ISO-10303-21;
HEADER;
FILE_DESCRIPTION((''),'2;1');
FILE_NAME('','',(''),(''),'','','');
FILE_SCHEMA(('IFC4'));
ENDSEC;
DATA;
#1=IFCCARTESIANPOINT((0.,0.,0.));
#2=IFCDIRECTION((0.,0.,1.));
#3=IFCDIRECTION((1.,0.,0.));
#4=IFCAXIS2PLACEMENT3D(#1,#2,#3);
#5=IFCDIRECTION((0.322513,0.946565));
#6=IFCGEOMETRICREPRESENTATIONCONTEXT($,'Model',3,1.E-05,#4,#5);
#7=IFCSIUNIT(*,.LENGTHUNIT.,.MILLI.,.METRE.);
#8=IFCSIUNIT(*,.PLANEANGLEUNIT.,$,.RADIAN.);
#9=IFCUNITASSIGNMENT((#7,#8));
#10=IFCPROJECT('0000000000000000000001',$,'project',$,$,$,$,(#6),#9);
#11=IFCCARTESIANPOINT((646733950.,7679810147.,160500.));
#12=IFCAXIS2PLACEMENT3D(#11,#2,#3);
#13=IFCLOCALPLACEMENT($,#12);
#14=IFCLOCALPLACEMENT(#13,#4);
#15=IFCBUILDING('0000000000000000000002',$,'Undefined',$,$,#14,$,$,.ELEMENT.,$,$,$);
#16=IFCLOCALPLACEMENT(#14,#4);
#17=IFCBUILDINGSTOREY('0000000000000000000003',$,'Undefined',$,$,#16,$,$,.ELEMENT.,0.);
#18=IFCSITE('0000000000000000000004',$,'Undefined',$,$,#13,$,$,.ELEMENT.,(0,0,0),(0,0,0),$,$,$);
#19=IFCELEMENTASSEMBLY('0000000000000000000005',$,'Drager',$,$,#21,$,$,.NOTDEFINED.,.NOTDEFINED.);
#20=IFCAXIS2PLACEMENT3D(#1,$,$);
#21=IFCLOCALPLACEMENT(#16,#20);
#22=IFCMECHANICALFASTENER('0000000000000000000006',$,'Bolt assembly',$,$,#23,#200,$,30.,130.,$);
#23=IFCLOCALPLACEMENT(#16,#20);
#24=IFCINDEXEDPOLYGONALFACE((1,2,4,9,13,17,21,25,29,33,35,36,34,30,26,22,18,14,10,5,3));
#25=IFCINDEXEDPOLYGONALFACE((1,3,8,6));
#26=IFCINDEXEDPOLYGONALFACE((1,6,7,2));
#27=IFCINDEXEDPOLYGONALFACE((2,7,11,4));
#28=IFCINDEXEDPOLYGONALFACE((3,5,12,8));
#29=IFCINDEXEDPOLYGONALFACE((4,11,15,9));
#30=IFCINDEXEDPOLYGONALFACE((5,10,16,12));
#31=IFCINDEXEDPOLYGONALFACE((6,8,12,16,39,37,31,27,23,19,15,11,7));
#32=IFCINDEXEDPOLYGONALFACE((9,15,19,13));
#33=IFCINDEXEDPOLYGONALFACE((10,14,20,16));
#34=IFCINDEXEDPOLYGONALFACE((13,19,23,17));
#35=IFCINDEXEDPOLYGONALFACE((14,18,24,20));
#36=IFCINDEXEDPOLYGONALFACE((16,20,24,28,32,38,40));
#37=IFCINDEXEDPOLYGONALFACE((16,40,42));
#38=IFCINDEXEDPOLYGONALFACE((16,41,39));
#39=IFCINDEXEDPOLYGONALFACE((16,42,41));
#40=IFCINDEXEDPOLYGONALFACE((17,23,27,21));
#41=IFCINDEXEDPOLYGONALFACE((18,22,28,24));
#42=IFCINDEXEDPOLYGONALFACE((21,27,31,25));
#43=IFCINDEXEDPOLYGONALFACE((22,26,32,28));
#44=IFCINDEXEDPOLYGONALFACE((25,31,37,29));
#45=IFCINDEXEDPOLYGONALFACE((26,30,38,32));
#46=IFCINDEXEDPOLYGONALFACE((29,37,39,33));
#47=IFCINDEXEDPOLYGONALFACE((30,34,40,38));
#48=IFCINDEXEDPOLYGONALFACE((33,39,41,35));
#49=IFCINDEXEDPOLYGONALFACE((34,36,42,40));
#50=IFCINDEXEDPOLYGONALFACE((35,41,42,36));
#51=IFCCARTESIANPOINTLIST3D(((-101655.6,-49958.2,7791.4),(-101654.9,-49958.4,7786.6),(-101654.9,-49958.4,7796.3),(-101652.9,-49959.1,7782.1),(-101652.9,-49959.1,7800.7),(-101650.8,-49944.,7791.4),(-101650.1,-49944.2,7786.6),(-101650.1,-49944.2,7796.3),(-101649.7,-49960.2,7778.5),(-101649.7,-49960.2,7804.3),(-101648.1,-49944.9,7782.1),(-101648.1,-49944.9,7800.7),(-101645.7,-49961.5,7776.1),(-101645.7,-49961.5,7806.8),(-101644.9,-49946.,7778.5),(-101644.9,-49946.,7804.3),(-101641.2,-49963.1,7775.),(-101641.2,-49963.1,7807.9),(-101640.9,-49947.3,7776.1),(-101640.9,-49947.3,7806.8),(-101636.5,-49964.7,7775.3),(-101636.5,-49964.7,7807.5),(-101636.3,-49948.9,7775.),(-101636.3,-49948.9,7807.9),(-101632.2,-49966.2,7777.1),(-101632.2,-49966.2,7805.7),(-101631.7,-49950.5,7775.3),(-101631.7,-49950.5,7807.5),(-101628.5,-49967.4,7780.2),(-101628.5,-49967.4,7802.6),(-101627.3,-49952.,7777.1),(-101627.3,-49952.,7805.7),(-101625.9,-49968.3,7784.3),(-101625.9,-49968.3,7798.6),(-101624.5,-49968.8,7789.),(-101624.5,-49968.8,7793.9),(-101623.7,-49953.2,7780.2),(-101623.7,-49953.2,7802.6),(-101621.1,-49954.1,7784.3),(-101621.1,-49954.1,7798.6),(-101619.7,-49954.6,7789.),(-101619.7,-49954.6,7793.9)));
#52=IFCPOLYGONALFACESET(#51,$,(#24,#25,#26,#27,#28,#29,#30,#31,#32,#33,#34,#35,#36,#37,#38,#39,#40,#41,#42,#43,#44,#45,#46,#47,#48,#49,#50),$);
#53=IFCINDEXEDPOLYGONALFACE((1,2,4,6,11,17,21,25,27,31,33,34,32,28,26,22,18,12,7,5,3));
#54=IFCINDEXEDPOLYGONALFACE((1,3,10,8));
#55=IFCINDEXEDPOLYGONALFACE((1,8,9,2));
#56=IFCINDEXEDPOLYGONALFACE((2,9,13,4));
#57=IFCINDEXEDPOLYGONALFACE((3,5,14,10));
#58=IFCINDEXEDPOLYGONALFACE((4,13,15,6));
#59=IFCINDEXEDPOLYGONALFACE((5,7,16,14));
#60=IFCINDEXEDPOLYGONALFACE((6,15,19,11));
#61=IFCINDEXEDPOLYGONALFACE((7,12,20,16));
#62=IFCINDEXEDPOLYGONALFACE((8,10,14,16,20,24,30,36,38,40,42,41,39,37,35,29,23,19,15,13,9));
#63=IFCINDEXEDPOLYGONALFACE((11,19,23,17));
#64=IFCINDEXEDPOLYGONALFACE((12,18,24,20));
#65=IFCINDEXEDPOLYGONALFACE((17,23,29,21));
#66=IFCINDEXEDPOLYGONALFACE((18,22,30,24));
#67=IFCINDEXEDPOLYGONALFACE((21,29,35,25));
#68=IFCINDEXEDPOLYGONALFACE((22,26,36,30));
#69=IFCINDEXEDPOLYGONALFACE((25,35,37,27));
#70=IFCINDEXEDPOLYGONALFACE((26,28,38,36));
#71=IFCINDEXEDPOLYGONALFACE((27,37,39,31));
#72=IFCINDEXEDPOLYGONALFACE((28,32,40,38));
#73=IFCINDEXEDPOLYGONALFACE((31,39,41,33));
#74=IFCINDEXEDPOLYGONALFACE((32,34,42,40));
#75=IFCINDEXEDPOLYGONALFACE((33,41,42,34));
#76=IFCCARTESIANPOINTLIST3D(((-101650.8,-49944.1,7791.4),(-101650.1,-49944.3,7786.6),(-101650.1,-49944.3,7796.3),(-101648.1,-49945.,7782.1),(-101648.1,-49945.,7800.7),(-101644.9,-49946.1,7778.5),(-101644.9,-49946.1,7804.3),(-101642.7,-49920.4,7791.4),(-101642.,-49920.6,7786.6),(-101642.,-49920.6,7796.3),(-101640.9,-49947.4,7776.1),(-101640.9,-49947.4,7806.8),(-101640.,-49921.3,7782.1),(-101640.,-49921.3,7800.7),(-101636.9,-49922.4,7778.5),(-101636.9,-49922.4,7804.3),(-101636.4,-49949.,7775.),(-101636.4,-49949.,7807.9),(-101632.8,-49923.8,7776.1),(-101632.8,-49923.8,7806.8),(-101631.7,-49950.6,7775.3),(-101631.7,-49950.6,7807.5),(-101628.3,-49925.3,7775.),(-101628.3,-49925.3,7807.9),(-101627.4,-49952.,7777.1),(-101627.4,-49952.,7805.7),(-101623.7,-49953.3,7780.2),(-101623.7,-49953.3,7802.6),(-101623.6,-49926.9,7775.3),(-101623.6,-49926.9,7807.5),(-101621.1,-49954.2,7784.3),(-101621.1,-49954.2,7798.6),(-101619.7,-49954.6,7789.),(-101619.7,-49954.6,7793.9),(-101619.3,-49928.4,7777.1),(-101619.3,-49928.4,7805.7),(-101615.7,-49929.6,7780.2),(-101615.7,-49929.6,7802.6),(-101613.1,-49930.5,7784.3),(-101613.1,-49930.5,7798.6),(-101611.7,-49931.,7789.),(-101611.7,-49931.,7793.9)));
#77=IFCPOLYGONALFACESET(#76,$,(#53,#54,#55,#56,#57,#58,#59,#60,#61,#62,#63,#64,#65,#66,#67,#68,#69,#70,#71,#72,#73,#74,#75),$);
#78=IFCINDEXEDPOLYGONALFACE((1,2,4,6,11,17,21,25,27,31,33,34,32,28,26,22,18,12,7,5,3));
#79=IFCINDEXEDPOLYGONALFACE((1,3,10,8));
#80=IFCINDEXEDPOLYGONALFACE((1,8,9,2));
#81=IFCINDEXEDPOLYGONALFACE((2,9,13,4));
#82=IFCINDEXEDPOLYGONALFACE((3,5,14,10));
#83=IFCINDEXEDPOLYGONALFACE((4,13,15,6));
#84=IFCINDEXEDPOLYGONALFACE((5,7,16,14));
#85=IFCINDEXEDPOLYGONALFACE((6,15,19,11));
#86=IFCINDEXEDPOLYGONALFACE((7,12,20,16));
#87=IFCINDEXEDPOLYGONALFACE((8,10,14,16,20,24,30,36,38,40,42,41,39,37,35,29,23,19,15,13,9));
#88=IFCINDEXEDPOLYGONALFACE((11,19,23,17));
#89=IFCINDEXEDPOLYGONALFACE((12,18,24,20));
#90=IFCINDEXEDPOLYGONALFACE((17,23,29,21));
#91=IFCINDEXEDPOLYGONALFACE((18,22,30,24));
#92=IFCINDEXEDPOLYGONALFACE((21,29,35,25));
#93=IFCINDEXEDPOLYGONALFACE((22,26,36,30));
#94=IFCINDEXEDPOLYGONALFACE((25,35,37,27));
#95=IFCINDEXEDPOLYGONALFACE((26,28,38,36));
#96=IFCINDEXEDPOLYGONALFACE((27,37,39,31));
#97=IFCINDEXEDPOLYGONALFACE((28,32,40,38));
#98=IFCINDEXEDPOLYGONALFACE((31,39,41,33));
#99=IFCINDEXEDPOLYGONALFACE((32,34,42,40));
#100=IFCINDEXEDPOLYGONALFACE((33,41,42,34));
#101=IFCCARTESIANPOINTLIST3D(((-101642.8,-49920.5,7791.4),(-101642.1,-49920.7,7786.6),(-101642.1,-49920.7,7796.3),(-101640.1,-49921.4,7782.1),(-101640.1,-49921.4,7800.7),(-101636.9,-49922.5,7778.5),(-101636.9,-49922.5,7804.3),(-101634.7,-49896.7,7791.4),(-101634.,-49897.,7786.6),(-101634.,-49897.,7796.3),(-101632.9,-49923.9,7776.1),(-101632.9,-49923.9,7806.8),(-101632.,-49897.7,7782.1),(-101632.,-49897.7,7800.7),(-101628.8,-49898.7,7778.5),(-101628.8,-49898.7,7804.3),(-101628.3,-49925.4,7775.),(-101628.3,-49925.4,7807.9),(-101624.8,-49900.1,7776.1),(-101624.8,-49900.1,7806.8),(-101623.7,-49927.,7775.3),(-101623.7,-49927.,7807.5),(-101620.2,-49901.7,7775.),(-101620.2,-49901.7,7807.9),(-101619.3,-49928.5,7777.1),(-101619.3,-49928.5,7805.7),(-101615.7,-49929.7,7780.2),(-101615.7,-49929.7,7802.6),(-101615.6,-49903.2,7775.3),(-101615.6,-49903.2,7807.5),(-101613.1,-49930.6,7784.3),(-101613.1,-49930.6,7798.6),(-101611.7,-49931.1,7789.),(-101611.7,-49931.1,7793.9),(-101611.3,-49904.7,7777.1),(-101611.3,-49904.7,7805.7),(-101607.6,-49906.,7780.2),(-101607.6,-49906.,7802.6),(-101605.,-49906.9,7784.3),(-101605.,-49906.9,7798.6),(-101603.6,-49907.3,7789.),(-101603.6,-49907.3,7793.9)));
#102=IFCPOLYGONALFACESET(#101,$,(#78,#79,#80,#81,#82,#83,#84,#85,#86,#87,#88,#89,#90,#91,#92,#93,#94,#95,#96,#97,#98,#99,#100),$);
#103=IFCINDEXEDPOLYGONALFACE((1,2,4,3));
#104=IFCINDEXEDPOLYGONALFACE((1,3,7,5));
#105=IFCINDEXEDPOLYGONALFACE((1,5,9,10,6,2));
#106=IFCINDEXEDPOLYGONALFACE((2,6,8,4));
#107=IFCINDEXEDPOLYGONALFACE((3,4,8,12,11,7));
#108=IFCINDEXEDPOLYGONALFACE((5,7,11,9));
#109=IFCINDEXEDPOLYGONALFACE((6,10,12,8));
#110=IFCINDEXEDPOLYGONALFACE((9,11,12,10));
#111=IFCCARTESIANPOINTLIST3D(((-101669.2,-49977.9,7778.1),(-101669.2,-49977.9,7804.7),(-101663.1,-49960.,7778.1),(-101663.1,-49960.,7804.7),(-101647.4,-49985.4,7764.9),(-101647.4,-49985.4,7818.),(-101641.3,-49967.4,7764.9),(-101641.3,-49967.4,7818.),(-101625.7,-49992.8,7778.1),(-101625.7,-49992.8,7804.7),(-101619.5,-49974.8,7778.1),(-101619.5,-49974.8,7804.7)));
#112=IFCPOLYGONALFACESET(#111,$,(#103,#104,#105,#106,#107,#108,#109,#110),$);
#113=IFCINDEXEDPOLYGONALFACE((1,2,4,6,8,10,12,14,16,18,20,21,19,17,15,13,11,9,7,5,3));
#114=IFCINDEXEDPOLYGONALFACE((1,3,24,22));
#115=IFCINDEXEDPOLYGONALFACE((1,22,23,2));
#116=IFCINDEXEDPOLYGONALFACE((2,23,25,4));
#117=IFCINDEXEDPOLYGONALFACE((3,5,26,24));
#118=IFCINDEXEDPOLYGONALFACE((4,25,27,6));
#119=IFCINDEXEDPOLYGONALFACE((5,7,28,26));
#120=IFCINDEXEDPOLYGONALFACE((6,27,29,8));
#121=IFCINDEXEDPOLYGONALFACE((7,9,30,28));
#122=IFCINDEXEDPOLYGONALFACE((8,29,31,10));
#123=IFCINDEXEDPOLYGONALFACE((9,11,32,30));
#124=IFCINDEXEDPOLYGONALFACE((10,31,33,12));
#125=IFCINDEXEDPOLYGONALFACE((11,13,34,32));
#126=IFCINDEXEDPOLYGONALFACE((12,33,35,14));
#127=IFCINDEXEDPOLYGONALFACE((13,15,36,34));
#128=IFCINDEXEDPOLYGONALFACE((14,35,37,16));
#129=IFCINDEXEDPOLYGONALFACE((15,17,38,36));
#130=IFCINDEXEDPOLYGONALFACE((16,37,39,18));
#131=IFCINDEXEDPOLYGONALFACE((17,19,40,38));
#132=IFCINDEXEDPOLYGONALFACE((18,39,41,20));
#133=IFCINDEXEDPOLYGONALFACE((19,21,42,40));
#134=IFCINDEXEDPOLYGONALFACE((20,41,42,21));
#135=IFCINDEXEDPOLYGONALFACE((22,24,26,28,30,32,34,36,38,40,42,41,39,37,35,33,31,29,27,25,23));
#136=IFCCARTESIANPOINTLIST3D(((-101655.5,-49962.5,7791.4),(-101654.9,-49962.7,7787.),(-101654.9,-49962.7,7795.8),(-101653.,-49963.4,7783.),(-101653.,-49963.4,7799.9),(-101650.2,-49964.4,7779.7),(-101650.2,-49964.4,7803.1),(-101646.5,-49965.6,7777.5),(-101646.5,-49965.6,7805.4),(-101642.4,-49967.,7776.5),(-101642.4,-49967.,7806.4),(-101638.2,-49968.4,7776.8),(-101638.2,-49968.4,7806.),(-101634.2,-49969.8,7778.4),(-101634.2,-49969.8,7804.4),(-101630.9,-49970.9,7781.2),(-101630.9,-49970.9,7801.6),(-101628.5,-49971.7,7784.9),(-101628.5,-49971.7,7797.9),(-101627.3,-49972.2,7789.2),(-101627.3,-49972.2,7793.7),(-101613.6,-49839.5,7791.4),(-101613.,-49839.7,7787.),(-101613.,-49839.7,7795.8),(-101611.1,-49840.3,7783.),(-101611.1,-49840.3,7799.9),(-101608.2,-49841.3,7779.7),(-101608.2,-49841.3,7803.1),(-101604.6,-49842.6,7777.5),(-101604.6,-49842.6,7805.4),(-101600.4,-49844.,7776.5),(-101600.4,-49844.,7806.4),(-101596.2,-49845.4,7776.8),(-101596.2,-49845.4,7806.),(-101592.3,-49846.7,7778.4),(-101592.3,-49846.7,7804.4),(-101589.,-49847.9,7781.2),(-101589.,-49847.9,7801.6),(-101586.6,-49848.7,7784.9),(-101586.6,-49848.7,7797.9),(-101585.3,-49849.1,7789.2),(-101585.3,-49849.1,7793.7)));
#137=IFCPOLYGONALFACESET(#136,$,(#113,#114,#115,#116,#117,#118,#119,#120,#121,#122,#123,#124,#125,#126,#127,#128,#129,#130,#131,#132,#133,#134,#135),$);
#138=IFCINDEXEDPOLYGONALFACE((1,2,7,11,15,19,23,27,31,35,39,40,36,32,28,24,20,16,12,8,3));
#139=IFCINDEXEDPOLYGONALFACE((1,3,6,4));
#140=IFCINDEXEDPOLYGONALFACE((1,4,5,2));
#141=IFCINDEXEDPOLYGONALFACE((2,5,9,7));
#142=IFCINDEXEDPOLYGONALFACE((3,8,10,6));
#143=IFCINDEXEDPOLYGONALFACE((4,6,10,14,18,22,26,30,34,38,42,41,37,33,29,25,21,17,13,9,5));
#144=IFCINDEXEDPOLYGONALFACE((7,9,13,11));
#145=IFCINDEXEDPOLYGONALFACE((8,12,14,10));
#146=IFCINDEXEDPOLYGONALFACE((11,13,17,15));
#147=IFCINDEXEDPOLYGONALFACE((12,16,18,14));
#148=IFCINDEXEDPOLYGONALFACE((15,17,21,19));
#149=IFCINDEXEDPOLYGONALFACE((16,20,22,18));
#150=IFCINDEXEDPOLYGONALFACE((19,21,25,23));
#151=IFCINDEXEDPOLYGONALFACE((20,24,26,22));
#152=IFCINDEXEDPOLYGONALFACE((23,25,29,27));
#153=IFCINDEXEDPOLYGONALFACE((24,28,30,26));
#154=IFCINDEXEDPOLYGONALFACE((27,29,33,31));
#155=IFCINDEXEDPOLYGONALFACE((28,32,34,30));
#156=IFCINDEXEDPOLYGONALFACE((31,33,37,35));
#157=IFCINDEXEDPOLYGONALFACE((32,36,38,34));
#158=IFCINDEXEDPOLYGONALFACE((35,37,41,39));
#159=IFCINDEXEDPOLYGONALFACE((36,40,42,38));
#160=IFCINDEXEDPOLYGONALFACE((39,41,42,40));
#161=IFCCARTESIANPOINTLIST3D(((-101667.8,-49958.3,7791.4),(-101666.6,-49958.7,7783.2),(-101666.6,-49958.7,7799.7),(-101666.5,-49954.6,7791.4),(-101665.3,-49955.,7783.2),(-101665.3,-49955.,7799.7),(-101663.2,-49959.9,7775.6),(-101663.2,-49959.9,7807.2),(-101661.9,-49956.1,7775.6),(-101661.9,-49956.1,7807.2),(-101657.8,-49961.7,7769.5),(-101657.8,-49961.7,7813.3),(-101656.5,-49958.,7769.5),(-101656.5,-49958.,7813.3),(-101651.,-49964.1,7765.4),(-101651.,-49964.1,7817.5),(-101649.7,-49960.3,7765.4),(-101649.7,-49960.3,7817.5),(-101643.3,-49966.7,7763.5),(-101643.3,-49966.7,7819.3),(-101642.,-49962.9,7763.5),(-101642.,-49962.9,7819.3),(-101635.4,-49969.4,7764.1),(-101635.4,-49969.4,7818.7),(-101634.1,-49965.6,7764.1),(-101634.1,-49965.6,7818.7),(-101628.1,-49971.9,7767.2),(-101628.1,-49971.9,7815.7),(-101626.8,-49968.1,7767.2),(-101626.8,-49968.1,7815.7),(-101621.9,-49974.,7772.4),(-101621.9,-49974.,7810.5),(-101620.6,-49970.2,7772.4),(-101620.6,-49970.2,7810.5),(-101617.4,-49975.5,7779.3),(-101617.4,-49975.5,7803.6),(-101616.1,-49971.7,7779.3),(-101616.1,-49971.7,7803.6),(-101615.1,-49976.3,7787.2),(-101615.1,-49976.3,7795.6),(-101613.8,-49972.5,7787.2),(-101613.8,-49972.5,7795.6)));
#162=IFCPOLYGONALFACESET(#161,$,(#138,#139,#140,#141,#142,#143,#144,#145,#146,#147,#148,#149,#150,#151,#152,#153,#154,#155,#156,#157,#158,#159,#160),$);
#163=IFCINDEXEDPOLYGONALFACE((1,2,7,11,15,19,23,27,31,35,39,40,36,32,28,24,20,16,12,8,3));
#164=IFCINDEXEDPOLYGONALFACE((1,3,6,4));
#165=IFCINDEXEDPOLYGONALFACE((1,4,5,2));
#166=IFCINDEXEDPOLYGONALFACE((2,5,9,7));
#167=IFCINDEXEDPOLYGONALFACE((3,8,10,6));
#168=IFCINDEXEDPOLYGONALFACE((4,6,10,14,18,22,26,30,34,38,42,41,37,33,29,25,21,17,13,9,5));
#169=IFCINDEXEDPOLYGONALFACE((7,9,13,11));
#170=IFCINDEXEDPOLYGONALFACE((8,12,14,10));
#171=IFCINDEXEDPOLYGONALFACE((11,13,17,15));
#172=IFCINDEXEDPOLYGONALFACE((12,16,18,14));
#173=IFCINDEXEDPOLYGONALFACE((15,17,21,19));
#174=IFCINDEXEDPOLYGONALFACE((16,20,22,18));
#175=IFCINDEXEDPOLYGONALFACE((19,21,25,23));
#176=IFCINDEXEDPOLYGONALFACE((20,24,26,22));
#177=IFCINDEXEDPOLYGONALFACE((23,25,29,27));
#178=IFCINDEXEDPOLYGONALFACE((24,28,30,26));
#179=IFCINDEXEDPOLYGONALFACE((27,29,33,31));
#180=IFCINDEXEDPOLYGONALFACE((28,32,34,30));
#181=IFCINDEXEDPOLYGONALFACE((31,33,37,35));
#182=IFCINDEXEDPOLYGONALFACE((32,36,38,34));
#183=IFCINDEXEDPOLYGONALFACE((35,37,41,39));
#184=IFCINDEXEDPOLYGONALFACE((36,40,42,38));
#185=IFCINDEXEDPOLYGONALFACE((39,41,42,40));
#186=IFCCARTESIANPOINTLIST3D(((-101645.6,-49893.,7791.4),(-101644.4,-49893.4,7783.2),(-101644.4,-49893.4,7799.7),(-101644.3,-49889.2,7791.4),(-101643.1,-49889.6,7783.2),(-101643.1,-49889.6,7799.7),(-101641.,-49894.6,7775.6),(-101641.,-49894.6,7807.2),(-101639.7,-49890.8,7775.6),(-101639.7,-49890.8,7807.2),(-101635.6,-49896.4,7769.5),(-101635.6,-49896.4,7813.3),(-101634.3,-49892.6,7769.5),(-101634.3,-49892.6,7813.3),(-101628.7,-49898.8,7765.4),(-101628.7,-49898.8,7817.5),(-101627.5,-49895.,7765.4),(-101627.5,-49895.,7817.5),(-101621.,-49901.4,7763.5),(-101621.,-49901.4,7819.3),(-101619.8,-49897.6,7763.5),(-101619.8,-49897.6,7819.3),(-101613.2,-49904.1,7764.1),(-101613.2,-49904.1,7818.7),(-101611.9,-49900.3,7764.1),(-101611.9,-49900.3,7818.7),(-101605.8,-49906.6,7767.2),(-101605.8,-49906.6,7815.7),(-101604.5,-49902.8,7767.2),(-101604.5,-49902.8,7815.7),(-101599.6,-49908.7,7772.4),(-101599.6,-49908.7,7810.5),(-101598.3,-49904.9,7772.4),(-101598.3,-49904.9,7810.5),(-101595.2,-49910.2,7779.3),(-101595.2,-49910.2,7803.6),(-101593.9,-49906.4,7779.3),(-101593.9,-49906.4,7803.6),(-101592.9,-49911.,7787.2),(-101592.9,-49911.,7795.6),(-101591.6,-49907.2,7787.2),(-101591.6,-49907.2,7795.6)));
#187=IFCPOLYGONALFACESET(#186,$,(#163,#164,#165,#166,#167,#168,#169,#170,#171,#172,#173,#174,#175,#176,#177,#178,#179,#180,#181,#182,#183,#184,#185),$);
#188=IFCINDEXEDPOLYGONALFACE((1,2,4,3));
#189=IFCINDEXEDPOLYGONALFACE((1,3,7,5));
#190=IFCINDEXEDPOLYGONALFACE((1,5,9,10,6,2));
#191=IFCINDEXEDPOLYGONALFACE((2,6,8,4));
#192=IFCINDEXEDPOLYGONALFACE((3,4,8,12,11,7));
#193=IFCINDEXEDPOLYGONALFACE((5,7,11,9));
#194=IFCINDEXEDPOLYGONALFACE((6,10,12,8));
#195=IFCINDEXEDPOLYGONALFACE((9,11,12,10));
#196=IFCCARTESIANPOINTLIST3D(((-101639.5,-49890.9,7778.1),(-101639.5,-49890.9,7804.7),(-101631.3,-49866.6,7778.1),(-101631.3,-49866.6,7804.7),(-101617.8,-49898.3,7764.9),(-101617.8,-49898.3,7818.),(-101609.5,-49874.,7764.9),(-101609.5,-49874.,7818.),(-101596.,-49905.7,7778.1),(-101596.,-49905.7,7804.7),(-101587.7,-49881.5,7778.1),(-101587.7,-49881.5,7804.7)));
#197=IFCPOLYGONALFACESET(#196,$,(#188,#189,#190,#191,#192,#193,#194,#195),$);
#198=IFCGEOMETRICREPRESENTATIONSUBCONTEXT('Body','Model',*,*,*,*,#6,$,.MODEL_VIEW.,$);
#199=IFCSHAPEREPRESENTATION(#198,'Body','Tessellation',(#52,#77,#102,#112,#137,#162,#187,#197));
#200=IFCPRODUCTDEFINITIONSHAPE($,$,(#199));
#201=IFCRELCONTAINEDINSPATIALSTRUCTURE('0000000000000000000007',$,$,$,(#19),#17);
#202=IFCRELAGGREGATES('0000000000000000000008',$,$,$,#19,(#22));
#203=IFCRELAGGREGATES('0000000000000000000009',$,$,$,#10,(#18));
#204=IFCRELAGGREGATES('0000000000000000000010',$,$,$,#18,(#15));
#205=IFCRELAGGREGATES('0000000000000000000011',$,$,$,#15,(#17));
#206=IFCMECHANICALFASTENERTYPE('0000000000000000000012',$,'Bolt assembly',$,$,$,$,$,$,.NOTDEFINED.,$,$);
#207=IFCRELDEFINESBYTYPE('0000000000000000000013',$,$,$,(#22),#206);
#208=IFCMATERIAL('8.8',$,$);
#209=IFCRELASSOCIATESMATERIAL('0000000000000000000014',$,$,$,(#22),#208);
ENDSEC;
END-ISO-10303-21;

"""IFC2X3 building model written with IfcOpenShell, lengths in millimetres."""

from ifc_helpers import new_model, si_unit, direction, frame, origin_with_axes, origin_2d_with_axis, place, context, subcontext, project, spatial, polyline, circle, outline, extrude, source, transform, mapped, material, type_object, element, aggregate, save


model = new_model("IFC2X3")

# Units and contexts
model_context = context("Model", 3, precision=1e-05, world=origin_with_axes(), true_north=direction((0.322513, 0.946565)))
body_context = subcontext(model_context, "Body", "Model", "MODEL_VIEW")
ifc_project = project(units=[si_unit("LENGTHUNIT", "METRE", prefix="MILLI"), si_unit("PLANEANGLEUNIT", "RADIAN")], contexts=[model_context])

# Site, building, storey
site_placement = place(None, frame((646733950.0, 7679810147.0, 160500.0), z_axis=(0.0, 0.0, 1.0), x_axis=(1.0, 0.0, 0.0)))
site = spatial("IfcSite", under=ifc_project, at=site_placement, Name="Undefined", CompositionType="ELEMENT", RefLatitude=(0, 0, 0), RefLongitude=(0, 0, 0))
building_placement = place(site_placement, origin_with_axes())
building = spatial("IfcBuilding", under=site, at=building_placement, Name="Undefined", CompositionType="ELEMENT")
storey_placement = place(building_placement, origin_with_axes())
storey = spatial("IfcBuildingStorey", under=building, at=storey_placement, Name="Undefined", CompositionType="ELEMENT", Elevation=0.0)

# Shared definitions
ifc_material_1 = material(Name="8.8")
mechanical_fastener_type = type_object("IfcMechanicalFastenerType", Name="Bolt assembly")

# Element assembly, mechanical fastener
assembly_1_placement = place(storey_placement, origin_with_axes())
assembly_1 = element("IfcElementAssembly", 1, at=assembly_1_placement, inside=storey, Name="Drager", AssemblyPlace="NOTDEFINED", PredefinedType="NOTDEFINED")
shared_shape_1 = source(origin_with_axes(), body_context, "Body", "SweptSolid", [
    extrude(circle(Radius=16.5, at=origin_2d_with_axis()), frame((0.0, -7.4, 0.0), z_axis=(0.0, 1.0, 0.0), x_axis=(1.0, 0.0, 0.0)), (0.0, 0.0, 1.0), 15.0),
    extrude(circle(Radius=16.5, at=origin_2d_with_axis()), frame((0.0, 7.5, 0.0), z_axis=(0.0, 1.0, 0.0), x_axis=(1.0, 0.0, 0.0)), (0.0, 0.0, 1.0), 25.0),
    extrude(circle(Radius=16.5, at=origin_2d_with_axis()), frame((0.0, 32.4, 0.0), z_axis=(0.0, 1.0, 0.0), x_axis=(1.0, 0.0, 0.0)), (0.0, 0.0, 1.0), 25.1),
    extrude(outline(polyline([(23.0, -13.3), (23.0, 13.3), (0.0, 26.6), (-23.0, 13.3), (-23.0, -13.3), (0.0, -26.6), (23.0, -13.3)])), frame((0.0, -30.5, 0.0), z_axis=(0.0, 1.0, 0.0), x_axis=(1.0, 0.0, 0.0)), (0.0, 0.0, 1.0), 19.0),
    extrude(circle(Radius=15.0, at=origin_2d_with_axis()), frame((0.0, -11.5, 0.0), z_axis=(0.0, 1.0, 0.0), x_axis=(1.0, 0.0, 0.0)), (0.0, 0.0, 1.0), 130.0),
    extrude(circle(Radius=28.0, at=origin_2d_with_axis()), frame((0.0, -11.5, 0.0), z_axis=(0.0, 1.0, 0.0), x_axis=(1.0, 0.0, 0.0)), (0.0, 0.0, 1.0), 4.0),
    extrude(circle(Radius=28.0, at=origin_2d_with_axis()), frame((0.0, 57.5, 0.0), z_axis=(0.0, 1.0, 0.0), x_axis=(1.0, 0.0, 0.0)), (0.0, 0.0, 1.0), 4.0),
    extrude(outline(polyline([(23.0, -13.3), (23.0, 13.3), (0.0, 26.6), (-23.0, 13.3), (-23.0, -13.3), (0.0, -26.6), (23.0, -13.3)])), frame((0.0, 61.5, 0.0), z_axis=(0.0, 1.0, 0.0), x_axis=(1.0, 0.0, 0.0)), (0.0, 0.0, 1.0), 25.6),
])
mechanical_fastener_1_placement = place(assembly_1_placement, frame((-101637.6, -49956.5, 7791.4), z_axis=(0.0, 0.0, -1.0), x_axis=(-0.946565, 0.322513, 0.0)))
mechanical_fastener_1 = element("IfcMechanicalFastener", 2, at=mechanical_fastener_1_placement, type_object=mechanical_fastener_type, material=ifc_material_1, Name="Bolt assembly", NominalDiameter=30.0, NominalLength=130.0, context=body_context, shape_type="MappedRepresentation", body=[
    mapped(shared_shape_1, transform((0.0, 0.0, 0.0))),
])
aggregate(assembly_1, [mechanical_fastener_1])

save(model, "model.ifc")
